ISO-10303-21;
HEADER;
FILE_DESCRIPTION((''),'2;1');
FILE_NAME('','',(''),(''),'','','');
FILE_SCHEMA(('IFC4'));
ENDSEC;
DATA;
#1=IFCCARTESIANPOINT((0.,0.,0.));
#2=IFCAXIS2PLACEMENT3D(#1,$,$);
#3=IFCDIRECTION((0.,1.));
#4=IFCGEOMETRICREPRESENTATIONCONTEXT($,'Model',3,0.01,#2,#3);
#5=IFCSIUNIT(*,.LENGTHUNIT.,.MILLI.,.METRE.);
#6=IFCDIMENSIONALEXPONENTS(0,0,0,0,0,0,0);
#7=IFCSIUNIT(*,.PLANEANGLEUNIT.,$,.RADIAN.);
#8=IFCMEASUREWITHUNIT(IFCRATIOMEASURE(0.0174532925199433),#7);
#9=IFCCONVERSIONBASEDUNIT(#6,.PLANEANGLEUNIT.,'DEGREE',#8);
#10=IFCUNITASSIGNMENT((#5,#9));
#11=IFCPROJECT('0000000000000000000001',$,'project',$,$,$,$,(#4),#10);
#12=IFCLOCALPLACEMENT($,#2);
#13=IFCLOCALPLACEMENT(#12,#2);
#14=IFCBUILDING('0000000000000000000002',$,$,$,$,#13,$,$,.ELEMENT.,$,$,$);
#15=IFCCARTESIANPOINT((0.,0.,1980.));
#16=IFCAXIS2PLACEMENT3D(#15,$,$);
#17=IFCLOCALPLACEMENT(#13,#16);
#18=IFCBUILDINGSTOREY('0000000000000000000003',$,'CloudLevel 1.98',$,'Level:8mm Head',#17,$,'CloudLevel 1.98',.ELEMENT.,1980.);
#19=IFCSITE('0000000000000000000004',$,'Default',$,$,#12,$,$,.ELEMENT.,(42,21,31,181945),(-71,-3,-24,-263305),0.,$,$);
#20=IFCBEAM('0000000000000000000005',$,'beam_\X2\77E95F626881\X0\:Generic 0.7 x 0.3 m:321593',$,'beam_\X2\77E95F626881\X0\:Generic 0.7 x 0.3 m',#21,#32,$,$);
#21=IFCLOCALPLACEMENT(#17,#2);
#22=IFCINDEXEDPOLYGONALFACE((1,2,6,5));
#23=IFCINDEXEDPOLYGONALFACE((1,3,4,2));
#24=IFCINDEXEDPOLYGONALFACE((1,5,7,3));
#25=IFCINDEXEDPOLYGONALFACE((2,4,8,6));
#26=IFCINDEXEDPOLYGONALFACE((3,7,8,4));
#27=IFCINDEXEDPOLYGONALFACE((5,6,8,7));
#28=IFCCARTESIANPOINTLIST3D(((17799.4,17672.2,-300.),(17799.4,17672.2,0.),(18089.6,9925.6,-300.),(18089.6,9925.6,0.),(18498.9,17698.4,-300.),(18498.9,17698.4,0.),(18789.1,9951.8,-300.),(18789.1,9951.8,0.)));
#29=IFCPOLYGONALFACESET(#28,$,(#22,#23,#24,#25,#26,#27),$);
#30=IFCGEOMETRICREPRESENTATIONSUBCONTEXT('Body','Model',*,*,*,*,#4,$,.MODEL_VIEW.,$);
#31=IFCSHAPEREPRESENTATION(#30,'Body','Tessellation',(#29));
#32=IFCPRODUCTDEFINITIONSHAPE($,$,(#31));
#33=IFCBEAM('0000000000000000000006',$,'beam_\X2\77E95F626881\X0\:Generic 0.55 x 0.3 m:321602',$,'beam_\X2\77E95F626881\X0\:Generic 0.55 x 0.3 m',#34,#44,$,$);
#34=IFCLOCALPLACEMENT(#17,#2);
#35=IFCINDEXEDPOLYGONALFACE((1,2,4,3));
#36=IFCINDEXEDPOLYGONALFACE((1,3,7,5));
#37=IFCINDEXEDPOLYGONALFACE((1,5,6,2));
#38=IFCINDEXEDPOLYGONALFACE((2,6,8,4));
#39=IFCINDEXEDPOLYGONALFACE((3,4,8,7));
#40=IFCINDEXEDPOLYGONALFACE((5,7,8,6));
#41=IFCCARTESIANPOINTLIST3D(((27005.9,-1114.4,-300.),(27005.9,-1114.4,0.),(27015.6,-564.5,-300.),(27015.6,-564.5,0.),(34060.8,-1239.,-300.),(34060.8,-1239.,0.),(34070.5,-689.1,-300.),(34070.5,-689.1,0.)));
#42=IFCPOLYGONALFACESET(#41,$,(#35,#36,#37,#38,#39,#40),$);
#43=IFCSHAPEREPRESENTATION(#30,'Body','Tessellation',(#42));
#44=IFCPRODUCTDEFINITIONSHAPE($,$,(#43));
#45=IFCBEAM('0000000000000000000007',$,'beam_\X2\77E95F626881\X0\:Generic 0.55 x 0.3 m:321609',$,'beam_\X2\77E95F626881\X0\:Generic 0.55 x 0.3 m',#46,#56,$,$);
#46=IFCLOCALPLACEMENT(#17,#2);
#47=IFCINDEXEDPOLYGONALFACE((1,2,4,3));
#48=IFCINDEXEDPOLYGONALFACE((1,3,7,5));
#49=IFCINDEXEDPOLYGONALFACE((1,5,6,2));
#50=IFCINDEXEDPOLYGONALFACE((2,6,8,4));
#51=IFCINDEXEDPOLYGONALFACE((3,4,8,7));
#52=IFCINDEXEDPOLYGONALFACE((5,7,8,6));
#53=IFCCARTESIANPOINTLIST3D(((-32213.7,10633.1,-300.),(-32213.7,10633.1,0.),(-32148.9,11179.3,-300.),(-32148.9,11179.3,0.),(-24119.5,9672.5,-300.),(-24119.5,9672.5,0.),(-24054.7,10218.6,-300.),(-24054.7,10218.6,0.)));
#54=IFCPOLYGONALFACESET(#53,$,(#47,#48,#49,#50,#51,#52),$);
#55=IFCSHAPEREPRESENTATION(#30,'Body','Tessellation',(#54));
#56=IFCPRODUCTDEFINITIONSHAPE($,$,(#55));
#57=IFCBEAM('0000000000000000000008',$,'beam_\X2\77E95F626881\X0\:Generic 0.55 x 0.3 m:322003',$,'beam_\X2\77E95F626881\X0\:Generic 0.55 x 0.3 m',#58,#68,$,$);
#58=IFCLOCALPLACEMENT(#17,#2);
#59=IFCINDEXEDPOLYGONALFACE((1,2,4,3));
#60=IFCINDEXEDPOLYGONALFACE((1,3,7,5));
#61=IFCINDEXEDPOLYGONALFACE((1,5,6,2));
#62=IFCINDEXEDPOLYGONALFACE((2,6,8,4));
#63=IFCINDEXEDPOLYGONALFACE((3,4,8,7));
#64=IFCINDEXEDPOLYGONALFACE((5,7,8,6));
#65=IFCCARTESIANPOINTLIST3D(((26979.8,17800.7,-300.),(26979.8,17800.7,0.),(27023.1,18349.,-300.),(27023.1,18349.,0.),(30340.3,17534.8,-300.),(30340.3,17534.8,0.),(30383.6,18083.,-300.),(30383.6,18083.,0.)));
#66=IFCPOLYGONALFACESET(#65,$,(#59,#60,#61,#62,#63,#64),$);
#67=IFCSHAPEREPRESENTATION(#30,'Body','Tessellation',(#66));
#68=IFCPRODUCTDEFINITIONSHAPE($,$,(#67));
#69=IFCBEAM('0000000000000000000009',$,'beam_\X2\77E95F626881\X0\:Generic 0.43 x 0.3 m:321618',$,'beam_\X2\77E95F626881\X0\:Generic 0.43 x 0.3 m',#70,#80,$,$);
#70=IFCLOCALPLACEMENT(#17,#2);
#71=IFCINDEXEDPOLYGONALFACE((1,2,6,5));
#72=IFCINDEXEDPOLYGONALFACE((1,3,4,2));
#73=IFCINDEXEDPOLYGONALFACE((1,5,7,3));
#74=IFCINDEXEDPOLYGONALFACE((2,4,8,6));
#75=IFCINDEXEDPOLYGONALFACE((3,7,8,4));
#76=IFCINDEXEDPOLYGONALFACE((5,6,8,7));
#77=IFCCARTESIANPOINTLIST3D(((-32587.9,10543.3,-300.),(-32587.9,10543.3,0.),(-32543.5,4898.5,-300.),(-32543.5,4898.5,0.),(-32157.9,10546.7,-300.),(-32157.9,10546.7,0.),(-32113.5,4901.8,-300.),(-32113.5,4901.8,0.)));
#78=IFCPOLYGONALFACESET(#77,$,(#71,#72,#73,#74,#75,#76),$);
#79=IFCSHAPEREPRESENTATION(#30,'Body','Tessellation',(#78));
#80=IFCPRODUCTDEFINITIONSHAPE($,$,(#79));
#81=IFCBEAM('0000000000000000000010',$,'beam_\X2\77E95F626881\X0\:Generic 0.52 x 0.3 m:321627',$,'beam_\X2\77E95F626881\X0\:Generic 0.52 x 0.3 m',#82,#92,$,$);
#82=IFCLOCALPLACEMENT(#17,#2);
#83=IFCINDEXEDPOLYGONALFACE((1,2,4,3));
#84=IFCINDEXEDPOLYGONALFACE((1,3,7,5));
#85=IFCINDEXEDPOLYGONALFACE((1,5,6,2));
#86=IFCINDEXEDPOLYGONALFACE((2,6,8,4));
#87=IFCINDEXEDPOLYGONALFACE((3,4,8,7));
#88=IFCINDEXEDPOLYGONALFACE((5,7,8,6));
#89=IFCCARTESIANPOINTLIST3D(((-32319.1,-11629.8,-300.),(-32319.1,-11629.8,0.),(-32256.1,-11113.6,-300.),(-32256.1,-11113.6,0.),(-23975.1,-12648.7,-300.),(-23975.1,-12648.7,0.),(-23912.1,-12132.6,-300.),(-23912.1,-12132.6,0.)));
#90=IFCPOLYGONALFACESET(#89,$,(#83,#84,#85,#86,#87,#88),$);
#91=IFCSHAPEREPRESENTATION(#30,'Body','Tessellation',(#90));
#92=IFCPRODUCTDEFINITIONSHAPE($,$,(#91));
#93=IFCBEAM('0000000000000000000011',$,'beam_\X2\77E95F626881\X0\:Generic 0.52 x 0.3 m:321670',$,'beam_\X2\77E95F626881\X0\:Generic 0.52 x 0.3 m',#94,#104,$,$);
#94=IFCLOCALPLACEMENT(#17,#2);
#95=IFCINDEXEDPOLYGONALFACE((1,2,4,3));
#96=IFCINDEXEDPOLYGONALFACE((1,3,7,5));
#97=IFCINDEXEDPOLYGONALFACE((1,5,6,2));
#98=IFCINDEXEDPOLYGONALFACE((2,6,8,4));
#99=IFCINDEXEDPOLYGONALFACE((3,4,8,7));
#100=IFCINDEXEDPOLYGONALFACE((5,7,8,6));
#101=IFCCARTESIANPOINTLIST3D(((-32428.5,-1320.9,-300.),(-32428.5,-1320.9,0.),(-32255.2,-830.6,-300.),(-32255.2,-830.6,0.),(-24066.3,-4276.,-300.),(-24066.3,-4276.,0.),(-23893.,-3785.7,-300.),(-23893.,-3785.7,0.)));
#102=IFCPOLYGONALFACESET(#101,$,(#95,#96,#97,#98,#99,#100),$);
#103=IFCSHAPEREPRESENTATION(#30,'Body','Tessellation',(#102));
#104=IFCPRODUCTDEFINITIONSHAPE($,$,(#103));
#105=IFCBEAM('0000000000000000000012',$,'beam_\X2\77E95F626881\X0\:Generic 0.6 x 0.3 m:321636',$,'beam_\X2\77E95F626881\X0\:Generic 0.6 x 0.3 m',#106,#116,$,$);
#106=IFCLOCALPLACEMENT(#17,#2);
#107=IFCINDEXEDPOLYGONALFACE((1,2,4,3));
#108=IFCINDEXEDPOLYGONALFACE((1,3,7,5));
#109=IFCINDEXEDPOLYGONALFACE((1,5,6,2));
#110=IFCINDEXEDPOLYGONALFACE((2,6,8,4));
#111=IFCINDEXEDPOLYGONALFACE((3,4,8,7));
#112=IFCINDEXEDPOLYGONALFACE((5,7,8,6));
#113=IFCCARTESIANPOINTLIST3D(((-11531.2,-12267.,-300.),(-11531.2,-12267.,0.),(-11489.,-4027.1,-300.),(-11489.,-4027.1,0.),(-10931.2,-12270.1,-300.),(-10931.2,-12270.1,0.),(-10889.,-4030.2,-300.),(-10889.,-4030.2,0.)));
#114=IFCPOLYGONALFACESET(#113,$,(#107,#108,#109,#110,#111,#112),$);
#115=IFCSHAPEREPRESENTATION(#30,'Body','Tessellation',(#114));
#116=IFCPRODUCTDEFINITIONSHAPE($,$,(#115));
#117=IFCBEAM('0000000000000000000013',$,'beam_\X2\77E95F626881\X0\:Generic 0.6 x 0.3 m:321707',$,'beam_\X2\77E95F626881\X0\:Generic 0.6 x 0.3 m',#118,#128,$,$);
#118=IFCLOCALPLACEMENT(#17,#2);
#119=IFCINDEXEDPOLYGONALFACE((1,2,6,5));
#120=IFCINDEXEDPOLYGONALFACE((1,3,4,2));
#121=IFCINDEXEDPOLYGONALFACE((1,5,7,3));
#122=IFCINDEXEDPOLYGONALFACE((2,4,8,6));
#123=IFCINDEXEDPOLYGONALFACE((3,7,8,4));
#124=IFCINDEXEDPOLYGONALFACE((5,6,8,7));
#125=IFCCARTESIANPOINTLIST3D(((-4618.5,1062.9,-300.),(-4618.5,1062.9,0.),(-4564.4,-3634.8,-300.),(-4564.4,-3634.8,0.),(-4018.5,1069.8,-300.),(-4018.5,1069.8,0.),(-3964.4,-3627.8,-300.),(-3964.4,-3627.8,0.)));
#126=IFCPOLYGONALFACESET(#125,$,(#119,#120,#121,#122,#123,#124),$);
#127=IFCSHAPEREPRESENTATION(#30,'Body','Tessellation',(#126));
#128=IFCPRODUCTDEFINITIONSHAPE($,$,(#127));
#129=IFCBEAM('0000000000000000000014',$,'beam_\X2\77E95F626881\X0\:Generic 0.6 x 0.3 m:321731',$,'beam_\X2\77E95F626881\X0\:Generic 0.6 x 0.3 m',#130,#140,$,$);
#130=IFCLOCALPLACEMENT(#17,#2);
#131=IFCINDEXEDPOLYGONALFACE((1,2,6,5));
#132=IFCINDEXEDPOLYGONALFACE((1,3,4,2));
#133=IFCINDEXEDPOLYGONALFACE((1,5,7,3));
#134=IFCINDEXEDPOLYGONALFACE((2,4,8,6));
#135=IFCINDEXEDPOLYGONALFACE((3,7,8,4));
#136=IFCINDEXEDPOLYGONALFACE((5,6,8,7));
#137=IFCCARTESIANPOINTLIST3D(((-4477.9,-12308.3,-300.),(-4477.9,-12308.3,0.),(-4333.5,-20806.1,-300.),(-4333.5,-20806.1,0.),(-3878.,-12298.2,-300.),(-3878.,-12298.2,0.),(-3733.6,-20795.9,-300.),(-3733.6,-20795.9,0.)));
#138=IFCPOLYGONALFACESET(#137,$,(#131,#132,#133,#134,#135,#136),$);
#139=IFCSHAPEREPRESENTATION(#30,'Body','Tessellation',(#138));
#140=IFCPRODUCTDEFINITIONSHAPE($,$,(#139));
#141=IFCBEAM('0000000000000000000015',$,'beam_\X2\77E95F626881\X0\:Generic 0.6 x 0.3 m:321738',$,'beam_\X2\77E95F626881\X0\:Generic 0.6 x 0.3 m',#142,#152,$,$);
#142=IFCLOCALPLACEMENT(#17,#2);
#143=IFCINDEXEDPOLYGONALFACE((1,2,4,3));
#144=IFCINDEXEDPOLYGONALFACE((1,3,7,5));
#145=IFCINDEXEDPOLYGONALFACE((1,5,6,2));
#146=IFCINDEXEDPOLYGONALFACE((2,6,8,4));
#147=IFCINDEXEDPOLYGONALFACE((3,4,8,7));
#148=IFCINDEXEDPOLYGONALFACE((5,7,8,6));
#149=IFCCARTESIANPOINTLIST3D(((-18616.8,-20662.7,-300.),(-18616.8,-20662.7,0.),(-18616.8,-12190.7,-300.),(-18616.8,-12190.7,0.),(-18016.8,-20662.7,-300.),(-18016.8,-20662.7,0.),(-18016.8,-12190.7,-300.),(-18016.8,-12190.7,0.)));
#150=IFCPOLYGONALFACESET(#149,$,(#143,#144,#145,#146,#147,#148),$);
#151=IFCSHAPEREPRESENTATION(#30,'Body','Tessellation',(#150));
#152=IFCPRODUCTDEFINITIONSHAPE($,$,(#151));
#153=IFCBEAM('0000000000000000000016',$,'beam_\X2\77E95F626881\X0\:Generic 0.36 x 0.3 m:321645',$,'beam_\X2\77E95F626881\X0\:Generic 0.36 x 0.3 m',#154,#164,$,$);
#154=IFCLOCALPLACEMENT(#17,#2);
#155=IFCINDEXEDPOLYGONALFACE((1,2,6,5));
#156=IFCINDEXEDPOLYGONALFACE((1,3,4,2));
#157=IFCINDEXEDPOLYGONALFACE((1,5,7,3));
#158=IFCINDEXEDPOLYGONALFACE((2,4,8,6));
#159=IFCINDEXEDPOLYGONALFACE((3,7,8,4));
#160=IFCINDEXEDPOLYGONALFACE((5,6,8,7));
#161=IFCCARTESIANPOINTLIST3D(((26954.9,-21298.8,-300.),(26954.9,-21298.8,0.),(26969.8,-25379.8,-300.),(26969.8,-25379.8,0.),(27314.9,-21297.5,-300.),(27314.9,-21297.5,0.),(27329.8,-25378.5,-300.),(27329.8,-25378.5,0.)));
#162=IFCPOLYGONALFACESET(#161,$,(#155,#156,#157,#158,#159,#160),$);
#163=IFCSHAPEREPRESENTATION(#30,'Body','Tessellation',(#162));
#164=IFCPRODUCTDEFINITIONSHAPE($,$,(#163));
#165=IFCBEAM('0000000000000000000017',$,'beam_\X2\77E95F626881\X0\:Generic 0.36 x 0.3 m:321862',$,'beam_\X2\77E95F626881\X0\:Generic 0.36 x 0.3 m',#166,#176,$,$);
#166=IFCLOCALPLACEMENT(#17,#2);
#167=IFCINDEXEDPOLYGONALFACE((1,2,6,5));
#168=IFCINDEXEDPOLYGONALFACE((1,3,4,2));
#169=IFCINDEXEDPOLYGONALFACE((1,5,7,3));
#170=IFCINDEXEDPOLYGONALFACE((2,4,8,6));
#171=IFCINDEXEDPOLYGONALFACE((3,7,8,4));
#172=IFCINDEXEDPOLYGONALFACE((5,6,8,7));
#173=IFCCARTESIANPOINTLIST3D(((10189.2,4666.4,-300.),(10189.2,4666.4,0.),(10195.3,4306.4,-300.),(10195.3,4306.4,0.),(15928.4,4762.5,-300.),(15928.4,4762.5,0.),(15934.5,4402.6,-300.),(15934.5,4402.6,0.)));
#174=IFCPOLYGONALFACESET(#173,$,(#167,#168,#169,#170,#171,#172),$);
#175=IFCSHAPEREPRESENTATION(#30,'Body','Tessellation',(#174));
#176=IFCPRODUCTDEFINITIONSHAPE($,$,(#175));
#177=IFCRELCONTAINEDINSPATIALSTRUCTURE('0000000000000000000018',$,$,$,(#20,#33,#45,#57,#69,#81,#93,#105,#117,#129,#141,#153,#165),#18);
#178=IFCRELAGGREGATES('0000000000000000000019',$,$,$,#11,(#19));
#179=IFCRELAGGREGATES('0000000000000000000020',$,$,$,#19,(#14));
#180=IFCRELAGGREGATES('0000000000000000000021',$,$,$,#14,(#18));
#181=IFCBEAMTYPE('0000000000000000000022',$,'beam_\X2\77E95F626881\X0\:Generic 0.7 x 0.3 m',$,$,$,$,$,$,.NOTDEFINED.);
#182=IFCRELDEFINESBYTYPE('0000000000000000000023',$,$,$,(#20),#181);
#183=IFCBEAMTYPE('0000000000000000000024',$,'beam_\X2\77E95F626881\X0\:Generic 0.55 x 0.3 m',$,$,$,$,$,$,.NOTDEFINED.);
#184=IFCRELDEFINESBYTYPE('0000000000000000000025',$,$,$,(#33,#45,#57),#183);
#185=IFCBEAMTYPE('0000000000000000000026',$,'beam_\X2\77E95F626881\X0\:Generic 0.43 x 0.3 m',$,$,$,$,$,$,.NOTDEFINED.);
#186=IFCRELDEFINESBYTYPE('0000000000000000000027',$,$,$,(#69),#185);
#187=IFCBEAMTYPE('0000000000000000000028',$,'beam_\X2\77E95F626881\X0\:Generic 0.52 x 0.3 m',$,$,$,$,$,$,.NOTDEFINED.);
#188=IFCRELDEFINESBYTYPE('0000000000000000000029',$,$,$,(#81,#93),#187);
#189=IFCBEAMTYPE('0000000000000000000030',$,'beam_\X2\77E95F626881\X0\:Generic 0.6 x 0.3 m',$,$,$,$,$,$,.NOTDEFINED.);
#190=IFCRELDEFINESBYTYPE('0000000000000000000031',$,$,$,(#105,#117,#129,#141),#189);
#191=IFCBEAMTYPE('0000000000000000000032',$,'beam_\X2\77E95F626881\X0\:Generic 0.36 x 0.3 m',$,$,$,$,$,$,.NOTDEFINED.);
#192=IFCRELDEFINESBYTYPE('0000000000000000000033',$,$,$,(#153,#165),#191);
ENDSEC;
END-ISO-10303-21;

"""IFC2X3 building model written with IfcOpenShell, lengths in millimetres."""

from ifc_helpers import new_model, entity, si_unit, converted_unit, direction, frame, frame_2d, origin, place, context, subcontext, project, spatial, rectangle, extrude, type_object, element, save


model = new_model("IFC2X3")

# Units and contexts
model_context = context("Model", 3, precision=0.01, world=origin(), true_north=direction((0.0, 1.0)))
body_context = subcontext(model_context, "Body", "Model", "MODEL_VIEW")
ifc_project = project(units=[si_unit("LENGTHUNIT", "METRE", prefix="MILLI"), converted_unit("PLANEANGLEUNIT", "DEGREE", entity("IfcRatioMeasure", 0.0174532925199433), si_unit("PLANEANGLEUNIT", "RADIAN"), dimensions=[0, 0, 0, 0, 0, 0, 0])], contexts=[model_context])

# Site, building, storey
site_placement = place(None, origin())
site = spatial("IfcSite", under=ifc_project, at=site_placement, Name="Default", CompositionType="ELEMENT", RefLatitude=(42, 21, 31, 181945), RefLongitude=(-71, -3, -24, -263305), RefElevation=0.0)
building_placement = place(site_placement, origin())
building = spatial("IfcBuilding", under=site, at=building_placement, CompositionType="ELEMENT")
storey_placement = place(building_placement, frame((0.0, 0.0, 1980.0)))
storey = spatial("IfcBuildingStorey", under=building, at=storey_placement, Name="CloudLevel 1.98", ObjectType="Level:8mm Head", LongName="CloudLevel 1.98", CompositionType="ELEMENT", Elevation=1980.0)

# Beams
beam_type_1 = type_object("IfcBeamType", Name="beam_矩形梁:Generic 0.7 x 0.3 m", PredefinedType="NOTDEFINED")
beam_1_placement = place(storey_placement, frame((18149.2, 17685.4, 0.0), z_axis=(0.0, 0.0, 1.0), x_axis=(0.037424, -0.999299, 0.0)))
element("IfcBeam", 1, at=beam_1_placement, inside=storey, type_object=beam_type_1, Name="beam_矩形梁:Generic 0.7 x 0.3 m:321593", ObjectType="beam_矩形梁:Generic 0.7 x 0.3 m", context=body_context, shape_type="SweptSolid", body=[
    extrude(rectangle(XDim=300.0, YDim=700.0, at=frame_2d((0.0, 0.0), x_axis=(1.0, 0.0))), frame((0.1, 0.0, -150.0), z_axis=(1.0, 0.0, 0.0), x_axis=(0.0, 0.0, -1.0)), (0.0, 0.0, 1.0), 7752.0),
])
beam_type_2 = type_object("IfcBeamType", Name="beam_矩形梁:Generic 0.55 x 0.3 m", PredefinedType="NOTDEFINED")
beam_2_placement = place(storey_placement, frame((34066.2, -964.0, 0.0), z_axis=(0.0, 0.0, 1.0), x_axis=(-0.999844, 0.017654, 0.0)))
element("IfcBeam", 2, at=beam_2_placement, inside=storey, type_object=beam_type_2, Name="beam_矩形梁:Generic 0.55 x 0.3 m:321602", ObjectType="beam_矩形梁:Generic 0.55 x 0.3 m", context=body_context, shape_type="SweptSolid", body=[
    extrude(rectangle(XDim=300.0, YDim=550.0, at=frame_2d((0.0, 0.0), x_axis=(1.0, 0.0))), frame((0.5, 0.0, -150.0), z_axis=(1.0, 0.0, 0.0), x_axis=(0.0, 0.0, -1.0)), (0.0, 0.0, 1.0), 7056.0),
])
beam_3_placement = place(storey_placement, frame((-32181.3, 10906.2, 0.0), z_axis=(0.0, 0.0, 1.0), x_axis=(0.993031, -0.117854, 0.0)))
element("IfcBeam", 3, at=beam_3_placement, inside=storey, type_object=beam_type_2, Name="beam_矩形梁:Generic 0.55 x 0.3 m:321609", ObjectType="beam_矩形梁:Generic 0.55 x 0.3 m", context=body_context, shape_type="SweptSolid", body=[
    extrude(rectangle(XDim=300.0, YDim=550.0, at=frame_2d((0.0, 0.0), x_axis=(1.0, 0.0))), frame((0.0, 0.0, -150.0), z_axis=(1.0, 0.0, 0.0), x_axis=(0.0, 0.0, -1.0)), (0.0, 0.0, 1.0), 8151.0),
])
beam_4_placement = place(storey_placement, frame((30362.4, 17808.9, 0.0), z_axis=(0.0, 0.0, 1.0), x_axis=(-0.996884, 0.078883, 0.0)))
element("IfcBeam", 4, at=beam_4_placement, inside=storey, type_object=beam_type_2, Name="beam_矩形梁:Generic 0.55 x 0.3 m:322003", ObjectType="beam_矩形梁:Generic 0.55 x 0.3 m", context=body_context, shape_type="SweptSolid", body=[
    extrude(rectangle(XDim=300.0, YDim=550.0, at=frame_2d((0.0, 0.0), x_axis=(1.0, 0.0))), frame((0.5, 0.0, -150.0), z_axis=(1.0, 0.0, 0.0), x_axis=(0.0, 0.0, -1.0)), (0.0, 0.0, 1.0), 3371.0),
])
beam_type_3 = type_object("IfcBeamType", Name="beam_矩形梁:Generic 0.43 x 0.3 m", PredefinedType="NOTDEFINED")
beam_5_placement = place(storey_placement, frame((-32372.9, 10545.0, 0.0), z_axis=(0.0, 0.0, 1.0), x_axis=(0.00787, -0.999969, 0.0)))
element("IfcBeam", 5, at=beam_5_placement, inside=storey, type_object=beam_type_3, Name="beam_矩形梁:Generic 0.43 x 0.3 m:321618", ObjectType="beam_矩形梁:Generic 0.43 x 0.3 m", context=body_context, shape_type="SweptSolid", body=[
    extrude(rectangle(XDim=300.0, YDim=430.0, at=frame_2d((0.0, 0.0), x_axis=(1.0, 0.0))), frame((0.1, 0.0, -150.0), z_axis=(1.0, 0.0, 0.0), x_axis=(0.0, 0.0, -1.0)), (0.0, 0.0, 1.0), 5645.0),
])
beam_type_4 = type_object("IfcBeamType", Name="beam_矩形梁:Generic 0.52 x 0.3 m", PredefinedType="NOTDEFINED")
beam_6_placement = place(storey_placement, frame((-23943.1, -12390.7, 0.0), z_axis=(0.0, 0.0, 1.0), x_axis=(-0.992626, 0.121219, 0.0)))
element("IfcBeam", 6, at=beam_6_placement, inside=storey, type_object=beam_type_4, Name="beam_矩形梁:Generic 0.52 x 0.3 m:321627", ObjectType="beam_矩形梁:Generic 0.52 x 0.3 m", context=body_context, shape_type="SweptSolid", body=[
    extrude(rectangle(XDim=300.0, YDim=520.0, at=frame_2d((0.0, 0.0), x_axis=(1.0, 0.0))), frame((0.4, 0.0, -150.0), z_axis=(1.0, 0.0, 0.0), x_axis=(0.0, 0.0, -1.0)), (0.0, 0.0, 1.0), 8406.0),
])
beam_7_placement = place(storey_placement, frame((-23979.4, -4030.9, 0.0), z_axis=(0.0, 0.0, 1.0), x_axis=(-0.942859, 0.333191, 0.0)))
element("IfcBeam", 7, at=beam_7_placement, inside=storey, type_object=beam_type_4, Name="beam_矩形梁:Generic 0.52 x 0.3 m:321670", ObjectType="beam_矩形梁:Generic 0.52 x 0.3 m", context=body_context, shape_type="SweptSolid", body=[
    extrude(rectangle(XDim=300.0, YDim=520.0, at=frame_2d((0.0, 0.0), x_axis=(1.0, 0.0))), frame((0.3, 0.0, -150.0), z_axis=(1.0, 0.0, 0.0), x_axis=(0.0, 0.0, -1.0)), (0.0, 0.0, 1.0), 8869.0),
])
beam_type_5 = type_object("IfcBeamType", Name="beam_矩形梁:Generic 0.6 x 0.3 m", PredefinedType="NOTDEFINED")
beam_8_placement = place(storey_placement, frame((-11189.0, -4028.6, 0.0), z_axis=(0.0, 0.0, 1.0), x_axis=(-0.005119, -0.999987, 0.0)))
element("IfcBeam", 8, at=beam_8_placement, inside=storey, type_object=beam_type_5, Name="beam_矩形梁:Generic 0.6 x 0.3 m:321636", ObjectType="beam_矩形梁:Generic 0.6 x 0.3 m", context=body_context, shape_type="SweptSolid", body=[
    extrude(rectangle(XDim=300.0, YDim=600.0, at=frame_2d((0.0, 0.0), x_axis=(1.0, 0.0))), frame((0.1, 0.0, -150.0), z_axis=(1.0, 0.0, 0.0), x_axis=(0.0, 0.0, -1.0)), (0.0, 0.0, 1.0), 8240.0),
])
beam_9_placement = place(storey_placement, frame((-4318.5, 1066.5, 0.0), z_axis=(0.0, 0.0, 1.0), x_axis=(0.011515, -0.999934, 0.0)))
element("IfcBeam", 9, at=beam_9_placement, inside=storey, type_object=beam_type_5, Name="beam_矩形梁:Generic 0.6 x 0.3 m:321707", ObjectType="beam_矩形梁:Generic 0.6 x 0.3 m", context=body_context, shape_type="SweptSolid", body=[
    extrude(rectangle(XDim=300.0, YDim=600.0, at=frame_2d((0.0, 0.0), x_axis=(1.0, 0.0))), frame((0.1, 0.0, -150.0), z_axis=(1.0, 0.0, 0.0), x_axis=(0.0, 0.0, -1.0)), (0.0, 0.0, 1.0), 4698.0),
])
beam_10_placement = place(storey_placement, frame((-4178.0, -12302.7, 0.0), z_axis=(0.0, 0.0, 1.0), x_axis=(0.016994, -0.999856, 0.0)))
element("IfcBeam", 10, at=beam_10_placement, inside=storey, type_object=beam_type_5, Name="beam_矩形梁:Generic 0.6 x 0.3 m:321731", ObjectType="beam_矩形梁:Generic 0.6 x 0.3 m", context=body_context, shape_type="SweptSolid", body=[
    extrude(rectangle(XDim=300.0, YDim=600.0, at=frame_2d((0.0, 0.0), x_axis=(1.0, 0.0))), frame((0.5, 0.0, -150.0), z_axis=(1.0, 0.0, 0.0), x_axis=(0.0, 0.0, -1.0)), (0.0, 0.0, 1.0), 8499.0),
])
beam_11_placement = place(storey_placement, frame((-18316.8, -12190.5, 0.0), z_axis=(0.0, 0.0, 1.0), x_axis=(0.0, -1.0, 0.0)))
element("IfcBeam", 11, at=beam_11_placement, inside=storey, type_object=beam_type_5, Name="beam_矩形梁:Generic 0.6 x 0.3 m:321738", ObjectType="beam_矩形梁:Generic 0.6 x 0.3 m", context=body_context, shape_type="SweptSolid", body=[
    extrude(rectangle(XDim=300.0, YDim=600.0, at=frame_2d((0.0, 0.0), x_axis=(1.0, 0.0))), frame((0.1, 0.0, -150.0), z_axis=(1.0, 0.0, 0.0), x_axis=(0.0, 0.0, -1.0)), (0.0, 0.0, 1.0), 8472.0),
])
beam_type_6 = type_object("IfcBeamType", Name="beam_矩形梁:Generic 0.36 x 0.3 m", PredefinedType="NOTDEFINED")
beam_12_placement = place(storey_placement, frame((27134.9, -21297.7, 0.0), z_axis=(0.0, 0.0, 1.0), x_axis=(0.003656, -0.999993, 0.0)))
element("IfcBeam", 12, at=beam_12_placement, inside=storey, type_object=beam_type_6, Name="beam_矩形梁:Generic 0.36 x 0.3 m:321645", ObjectType="beam_矩形梁:Generic 0.36 x 0.3 m", context=body_context, shape_type="SweptSolid", body=[
    extrude(rectangle(XDim=300.0, YDim=360.0, at=frame_2d((0.0, 0.0), x_axis=(1.0, 0.0))), frame((0.4, 0.0, -150.0), z_axis=(1.0, 0.0, 0.0), x_axis=(0.0, 0.0, -1.0)), (0.0, 0.0, 1.0), 4081.0),
])
beam_13_placement = place(storey_placement, frame((10192.1, 4486.4, 0.0), z_axis=(0.0, 0.0, 1.0), x_axis=(0.99986, 0.01675, 0.0)))
element("IfcBeam", 13, at=beam_13_placement, inside=storey, type_object=beam_type_6, Name="beam_矩形梁:Generic 0.36 x 0.3 m:321862", ObjectType="beam_矩形梁:Generic 0.36 x 0.3 m", context=body_context, shape_type="SweptSolid", body=[
    extrude(rectangle(XDim=300.0, YDim=360.0, at=frame_2d((0.0, 0.0), x_axis=(1.0, 0.0))), frame((0.1, 0.0, -150.0), z_axis=(1.0, 0.0, 0.0), x_axis=(0.0, 0.0, -1.0)), (0.0, 0.0, 1.0), 5740.0),
])

save(model, "model.ifc")
